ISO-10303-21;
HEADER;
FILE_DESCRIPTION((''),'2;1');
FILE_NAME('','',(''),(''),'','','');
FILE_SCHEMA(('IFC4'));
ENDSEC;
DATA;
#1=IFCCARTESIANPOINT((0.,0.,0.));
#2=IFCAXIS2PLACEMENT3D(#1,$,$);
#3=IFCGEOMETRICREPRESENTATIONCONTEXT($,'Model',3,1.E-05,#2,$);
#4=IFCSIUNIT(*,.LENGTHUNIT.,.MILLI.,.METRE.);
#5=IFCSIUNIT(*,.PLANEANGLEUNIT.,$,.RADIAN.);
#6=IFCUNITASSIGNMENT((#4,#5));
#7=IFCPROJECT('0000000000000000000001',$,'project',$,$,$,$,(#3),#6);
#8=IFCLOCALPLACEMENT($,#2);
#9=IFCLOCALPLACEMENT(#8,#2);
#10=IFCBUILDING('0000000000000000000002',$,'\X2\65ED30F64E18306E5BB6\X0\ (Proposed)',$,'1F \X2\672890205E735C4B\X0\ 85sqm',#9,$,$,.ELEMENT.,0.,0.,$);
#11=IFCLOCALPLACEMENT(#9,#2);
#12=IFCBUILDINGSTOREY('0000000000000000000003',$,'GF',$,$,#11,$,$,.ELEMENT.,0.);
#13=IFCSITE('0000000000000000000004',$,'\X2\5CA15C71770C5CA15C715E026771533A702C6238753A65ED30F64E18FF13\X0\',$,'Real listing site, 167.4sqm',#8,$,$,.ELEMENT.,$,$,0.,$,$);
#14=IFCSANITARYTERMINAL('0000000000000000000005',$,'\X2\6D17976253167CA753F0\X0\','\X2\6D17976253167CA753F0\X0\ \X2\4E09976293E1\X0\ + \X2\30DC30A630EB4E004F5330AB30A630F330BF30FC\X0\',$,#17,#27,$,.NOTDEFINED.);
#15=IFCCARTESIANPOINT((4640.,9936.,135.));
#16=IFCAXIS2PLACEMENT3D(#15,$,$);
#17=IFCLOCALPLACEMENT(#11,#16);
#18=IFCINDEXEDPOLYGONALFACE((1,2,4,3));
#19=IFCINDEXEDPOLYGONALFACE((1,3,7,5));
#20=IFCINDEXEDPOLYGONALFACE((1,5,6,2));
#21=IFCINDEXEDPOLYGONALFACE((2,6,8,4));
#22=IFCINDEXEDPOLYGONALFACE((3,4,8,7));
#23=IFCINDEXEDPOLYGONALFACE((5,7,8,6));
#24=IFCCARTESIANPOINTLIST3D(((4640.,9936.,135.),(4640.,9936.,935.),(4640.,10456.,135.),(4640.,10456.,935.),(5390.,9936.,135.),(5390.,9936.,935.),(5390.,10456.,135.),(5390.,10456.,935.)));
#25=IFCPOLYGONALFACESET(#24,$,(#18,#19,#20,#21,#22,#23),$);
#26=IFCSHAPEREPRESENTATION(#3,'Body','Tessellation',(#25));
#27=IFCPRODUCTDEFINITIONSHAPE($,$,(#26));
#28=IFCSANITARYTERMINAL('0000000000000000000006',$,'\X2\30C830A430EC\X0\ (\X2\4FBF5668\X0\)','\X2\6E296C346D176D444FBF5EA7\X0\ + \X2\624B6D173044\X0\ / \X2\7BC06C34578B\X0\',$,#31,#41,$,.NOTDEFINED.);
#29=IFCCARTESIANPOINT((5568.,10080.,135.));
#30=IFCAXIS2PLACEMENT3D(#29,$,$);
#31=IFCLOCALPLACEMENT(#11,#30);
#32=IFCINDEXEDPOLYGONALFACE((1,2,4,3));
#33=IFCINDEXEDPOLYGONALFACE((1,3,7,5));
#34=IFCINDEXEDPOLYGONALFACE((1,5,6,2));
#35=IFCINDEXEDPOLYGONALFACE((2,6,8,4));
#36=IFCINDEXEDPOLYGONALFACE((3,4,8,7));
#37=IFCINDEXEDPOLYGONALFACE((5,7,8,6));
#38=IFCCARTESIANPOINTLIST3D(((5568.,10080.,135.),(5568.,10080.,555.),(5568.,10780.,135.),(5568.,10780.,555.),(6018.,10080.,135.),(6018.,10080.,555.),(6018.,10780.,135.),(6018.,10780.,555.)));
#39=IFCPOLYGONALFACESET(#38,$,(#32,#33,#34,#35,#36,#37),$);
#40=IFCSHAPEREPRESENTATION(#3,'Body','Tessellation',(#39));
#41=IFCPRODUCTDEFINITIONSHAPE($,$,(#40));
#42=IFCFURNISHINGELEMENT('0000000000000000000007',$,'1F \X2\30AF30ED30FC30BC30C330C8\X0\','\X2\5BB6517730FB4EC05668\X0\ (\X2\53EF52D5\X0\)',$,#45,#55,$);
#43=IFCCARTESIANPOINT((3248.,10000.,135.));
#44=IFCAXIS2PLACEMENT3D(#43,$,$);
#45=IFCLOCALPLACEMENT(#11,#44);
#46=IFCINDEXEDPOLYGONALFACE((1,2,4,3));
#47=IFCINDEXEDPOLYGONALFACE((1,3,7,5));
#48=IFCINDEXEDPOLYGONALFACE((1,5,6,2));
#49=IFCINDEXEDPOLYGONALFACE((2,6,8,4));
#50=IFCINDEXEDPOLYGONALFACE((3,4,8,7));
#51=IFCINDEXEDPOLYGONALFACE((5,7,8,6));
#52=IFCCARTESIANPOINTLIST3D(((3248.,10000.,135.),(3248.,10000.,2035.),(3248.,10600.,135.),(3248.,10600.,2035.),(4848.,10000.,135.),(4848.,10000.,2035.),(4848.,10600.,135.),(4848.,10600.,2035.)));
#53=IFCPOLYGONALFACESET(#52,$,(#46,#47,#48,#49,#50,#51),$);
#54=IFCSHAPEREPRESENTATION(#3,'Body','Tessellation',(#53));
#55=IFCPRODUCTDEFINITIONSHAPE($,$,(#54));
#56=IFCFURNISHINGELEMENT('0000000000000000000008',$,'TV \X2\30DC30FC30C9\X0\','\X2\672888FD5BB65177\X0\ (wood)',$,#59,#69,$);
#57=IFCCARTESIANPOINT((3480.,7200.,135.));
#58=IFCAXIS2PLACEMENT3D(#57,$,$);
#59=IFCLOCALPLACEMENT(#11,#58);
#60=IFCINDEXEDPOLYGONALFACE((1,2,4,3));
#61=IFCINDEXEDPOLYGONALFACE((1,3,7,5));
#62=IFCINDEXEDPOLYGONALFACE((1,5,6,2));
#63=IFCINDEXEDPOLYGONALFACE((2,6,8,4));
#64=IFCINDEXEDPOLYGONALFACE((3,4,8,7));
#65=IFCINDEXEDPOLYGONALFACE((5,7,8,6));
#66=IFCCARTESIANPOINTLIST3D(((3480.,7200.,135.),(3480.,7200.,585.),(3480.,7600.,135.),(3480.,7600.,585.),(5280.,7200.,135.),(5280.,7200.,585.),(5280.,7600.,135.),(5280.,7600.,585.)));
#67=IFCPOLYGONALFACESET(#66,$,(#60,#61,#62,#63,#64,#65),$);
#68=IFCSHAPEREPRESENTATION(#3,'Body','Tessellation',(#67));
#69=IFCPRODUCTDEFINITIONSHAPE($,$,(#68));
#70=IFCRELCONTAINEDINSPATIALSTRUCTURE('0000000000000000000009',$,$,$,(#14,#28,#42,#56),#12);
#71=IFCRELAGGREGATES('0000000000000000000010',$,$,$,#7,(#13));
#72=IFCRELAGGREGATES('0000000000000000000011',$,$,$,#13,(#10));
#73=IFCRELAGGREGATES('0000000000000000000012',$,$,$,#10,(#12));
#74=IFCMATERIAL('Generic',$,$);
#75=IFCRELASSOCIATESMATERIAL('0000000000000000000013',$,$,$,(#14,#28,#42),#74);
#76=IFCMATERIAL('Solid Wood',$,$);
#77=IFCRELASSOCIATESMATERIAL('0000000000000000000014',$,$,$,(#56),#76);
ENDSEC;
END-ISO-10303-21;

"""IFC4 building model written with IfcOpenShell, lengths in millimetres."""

from ifc_helpers import new_model, si_unit, frame, frame_2d, origin, place, context, project, spatial, rectangle, extrude, material, element, save


model = new_model("IFC4")

# Units and contexts
model_context = context("Model", 3, precision=1e-05, world=origin())
ifc_project = project(units=[si_unit("LENGTHUNIT", "METRE", prefix="MILLI"), si_unit("PLANEANGLEUNIT", "RADIAN")], contexts=[model_context])

# Site, building, storey
site_placement = place(None, origin())
site = spatial("IfcSite", under=ifc_project, at=site_placement, Name="岡山県岡山市東区瀬戸町旭ヶ丘３", ObjectType="Real listing site, 167.4sqm", CompositionType="ELEMENT", RefElevation=0.0)
building_placement = place(site_placement, origin())
building = spatial("IfcBuilding", under=site, at=building_placement, Name="旭ヶ丘の家 (Proposed)", ObjectType="1F 木造平屋 85sqm", CompositionType="ELEMENT", ElevationOfRefHeight=0.0, ElevationOfTerrain=0.0)
storey_placement = place(building_placement, origin())
storey = spatial("IfcBuildingStorey", under=building, at=storey_placement, Name="GF", CompositionType="ELEMENT", Elevation=0.0)

# Shared definitions
ifc_material_1 = material(Name="Solid Wood")

# Shared definitions
ifc_material_2 = material(Name="Generic")

# Sanitary terminals
sanitary_terminal_1_placement = place(storey_placement, frame((4640.0, 9936.0, 135.0)))
element("IfcSanitaryTerminal", 1, at=sanitary_terminal_1_placement, inside=storey, material=ifc_material_2, Name="洗面化粧台", Description="洗面化粧台 三面鏡 + ボウル一体カウンター", PredefinedType="NOTDEFINED", context=model_context, shape_type="SweptSolid", body=[
    extrude(rectangle(XDim=750.0, YDim=520.0, at=frame_2d((375.0, 260.0))), frame((4640.0, 9936.0, 135.0)), (0.0, 0.0, 1.0), 800.0),
])
sanitary_terminal_2_placement = place(storey_placement, frame((5568.0, 10080.0, 135.0)))
element("IfcSanitaryTerminal", 2, at=sanitary_terminal_2_placement, inside=storey, material=ifc_material_2, Name="トイレ (便器)", Description="温水洗浄便座 + 手洗い / 節水型", PredefinedType="NOTDEFINED", context=model_context, shape_type="SweptSolid", body=[
    extrude(rectangle(XDim=450.0, YDim=700.0, at=frame_2d((225.0, 350.0))), frame((5568.0, 10080.0, 135.0)), (0.0, 0.0, 1.0), 420.0),
])

# Furnishing elements
furnishing_1_placement = place(storey_placement, frame((3248.0, 10000.0, 135.0)))
element("IfcFurnishingElement", 3, at=furnishing_1_placement, inside=storey, material=ifc_material_2, Name="1F クローゼット", Description="家具・什器 (可動)", context=model_context, shape_type="SweptSolid", body=[
    extrude(rectangle(XDim=1600.0, YDim=600.0, at=frame_2d((800.0, 300.0))), frame((3248.0, 10000.0, 135.0)), (0.0, 0.0, 1.0), 1900.0),
])
furnishing_2_placement = place(storey_placement, frame((3480.0, 7200.0, 135.0)))
element("IfcFurnishingElement", 4, at=furnishing_2_placement, inside=storey, material=ifc_material_1, Name="TV ボード", Description="木製家具 (wood)", context=model_context, shape_type="SweptSolid", body=[
    extrude(rectangle(XDim=1800.0, YDim=400.0, at=frame_2d((900.0, 200.0))), frame((3480.0, 7200.0, 135.0)), (0.0, 0.0, 1.0), 450.0),
])

save(model, "model.ifc")
